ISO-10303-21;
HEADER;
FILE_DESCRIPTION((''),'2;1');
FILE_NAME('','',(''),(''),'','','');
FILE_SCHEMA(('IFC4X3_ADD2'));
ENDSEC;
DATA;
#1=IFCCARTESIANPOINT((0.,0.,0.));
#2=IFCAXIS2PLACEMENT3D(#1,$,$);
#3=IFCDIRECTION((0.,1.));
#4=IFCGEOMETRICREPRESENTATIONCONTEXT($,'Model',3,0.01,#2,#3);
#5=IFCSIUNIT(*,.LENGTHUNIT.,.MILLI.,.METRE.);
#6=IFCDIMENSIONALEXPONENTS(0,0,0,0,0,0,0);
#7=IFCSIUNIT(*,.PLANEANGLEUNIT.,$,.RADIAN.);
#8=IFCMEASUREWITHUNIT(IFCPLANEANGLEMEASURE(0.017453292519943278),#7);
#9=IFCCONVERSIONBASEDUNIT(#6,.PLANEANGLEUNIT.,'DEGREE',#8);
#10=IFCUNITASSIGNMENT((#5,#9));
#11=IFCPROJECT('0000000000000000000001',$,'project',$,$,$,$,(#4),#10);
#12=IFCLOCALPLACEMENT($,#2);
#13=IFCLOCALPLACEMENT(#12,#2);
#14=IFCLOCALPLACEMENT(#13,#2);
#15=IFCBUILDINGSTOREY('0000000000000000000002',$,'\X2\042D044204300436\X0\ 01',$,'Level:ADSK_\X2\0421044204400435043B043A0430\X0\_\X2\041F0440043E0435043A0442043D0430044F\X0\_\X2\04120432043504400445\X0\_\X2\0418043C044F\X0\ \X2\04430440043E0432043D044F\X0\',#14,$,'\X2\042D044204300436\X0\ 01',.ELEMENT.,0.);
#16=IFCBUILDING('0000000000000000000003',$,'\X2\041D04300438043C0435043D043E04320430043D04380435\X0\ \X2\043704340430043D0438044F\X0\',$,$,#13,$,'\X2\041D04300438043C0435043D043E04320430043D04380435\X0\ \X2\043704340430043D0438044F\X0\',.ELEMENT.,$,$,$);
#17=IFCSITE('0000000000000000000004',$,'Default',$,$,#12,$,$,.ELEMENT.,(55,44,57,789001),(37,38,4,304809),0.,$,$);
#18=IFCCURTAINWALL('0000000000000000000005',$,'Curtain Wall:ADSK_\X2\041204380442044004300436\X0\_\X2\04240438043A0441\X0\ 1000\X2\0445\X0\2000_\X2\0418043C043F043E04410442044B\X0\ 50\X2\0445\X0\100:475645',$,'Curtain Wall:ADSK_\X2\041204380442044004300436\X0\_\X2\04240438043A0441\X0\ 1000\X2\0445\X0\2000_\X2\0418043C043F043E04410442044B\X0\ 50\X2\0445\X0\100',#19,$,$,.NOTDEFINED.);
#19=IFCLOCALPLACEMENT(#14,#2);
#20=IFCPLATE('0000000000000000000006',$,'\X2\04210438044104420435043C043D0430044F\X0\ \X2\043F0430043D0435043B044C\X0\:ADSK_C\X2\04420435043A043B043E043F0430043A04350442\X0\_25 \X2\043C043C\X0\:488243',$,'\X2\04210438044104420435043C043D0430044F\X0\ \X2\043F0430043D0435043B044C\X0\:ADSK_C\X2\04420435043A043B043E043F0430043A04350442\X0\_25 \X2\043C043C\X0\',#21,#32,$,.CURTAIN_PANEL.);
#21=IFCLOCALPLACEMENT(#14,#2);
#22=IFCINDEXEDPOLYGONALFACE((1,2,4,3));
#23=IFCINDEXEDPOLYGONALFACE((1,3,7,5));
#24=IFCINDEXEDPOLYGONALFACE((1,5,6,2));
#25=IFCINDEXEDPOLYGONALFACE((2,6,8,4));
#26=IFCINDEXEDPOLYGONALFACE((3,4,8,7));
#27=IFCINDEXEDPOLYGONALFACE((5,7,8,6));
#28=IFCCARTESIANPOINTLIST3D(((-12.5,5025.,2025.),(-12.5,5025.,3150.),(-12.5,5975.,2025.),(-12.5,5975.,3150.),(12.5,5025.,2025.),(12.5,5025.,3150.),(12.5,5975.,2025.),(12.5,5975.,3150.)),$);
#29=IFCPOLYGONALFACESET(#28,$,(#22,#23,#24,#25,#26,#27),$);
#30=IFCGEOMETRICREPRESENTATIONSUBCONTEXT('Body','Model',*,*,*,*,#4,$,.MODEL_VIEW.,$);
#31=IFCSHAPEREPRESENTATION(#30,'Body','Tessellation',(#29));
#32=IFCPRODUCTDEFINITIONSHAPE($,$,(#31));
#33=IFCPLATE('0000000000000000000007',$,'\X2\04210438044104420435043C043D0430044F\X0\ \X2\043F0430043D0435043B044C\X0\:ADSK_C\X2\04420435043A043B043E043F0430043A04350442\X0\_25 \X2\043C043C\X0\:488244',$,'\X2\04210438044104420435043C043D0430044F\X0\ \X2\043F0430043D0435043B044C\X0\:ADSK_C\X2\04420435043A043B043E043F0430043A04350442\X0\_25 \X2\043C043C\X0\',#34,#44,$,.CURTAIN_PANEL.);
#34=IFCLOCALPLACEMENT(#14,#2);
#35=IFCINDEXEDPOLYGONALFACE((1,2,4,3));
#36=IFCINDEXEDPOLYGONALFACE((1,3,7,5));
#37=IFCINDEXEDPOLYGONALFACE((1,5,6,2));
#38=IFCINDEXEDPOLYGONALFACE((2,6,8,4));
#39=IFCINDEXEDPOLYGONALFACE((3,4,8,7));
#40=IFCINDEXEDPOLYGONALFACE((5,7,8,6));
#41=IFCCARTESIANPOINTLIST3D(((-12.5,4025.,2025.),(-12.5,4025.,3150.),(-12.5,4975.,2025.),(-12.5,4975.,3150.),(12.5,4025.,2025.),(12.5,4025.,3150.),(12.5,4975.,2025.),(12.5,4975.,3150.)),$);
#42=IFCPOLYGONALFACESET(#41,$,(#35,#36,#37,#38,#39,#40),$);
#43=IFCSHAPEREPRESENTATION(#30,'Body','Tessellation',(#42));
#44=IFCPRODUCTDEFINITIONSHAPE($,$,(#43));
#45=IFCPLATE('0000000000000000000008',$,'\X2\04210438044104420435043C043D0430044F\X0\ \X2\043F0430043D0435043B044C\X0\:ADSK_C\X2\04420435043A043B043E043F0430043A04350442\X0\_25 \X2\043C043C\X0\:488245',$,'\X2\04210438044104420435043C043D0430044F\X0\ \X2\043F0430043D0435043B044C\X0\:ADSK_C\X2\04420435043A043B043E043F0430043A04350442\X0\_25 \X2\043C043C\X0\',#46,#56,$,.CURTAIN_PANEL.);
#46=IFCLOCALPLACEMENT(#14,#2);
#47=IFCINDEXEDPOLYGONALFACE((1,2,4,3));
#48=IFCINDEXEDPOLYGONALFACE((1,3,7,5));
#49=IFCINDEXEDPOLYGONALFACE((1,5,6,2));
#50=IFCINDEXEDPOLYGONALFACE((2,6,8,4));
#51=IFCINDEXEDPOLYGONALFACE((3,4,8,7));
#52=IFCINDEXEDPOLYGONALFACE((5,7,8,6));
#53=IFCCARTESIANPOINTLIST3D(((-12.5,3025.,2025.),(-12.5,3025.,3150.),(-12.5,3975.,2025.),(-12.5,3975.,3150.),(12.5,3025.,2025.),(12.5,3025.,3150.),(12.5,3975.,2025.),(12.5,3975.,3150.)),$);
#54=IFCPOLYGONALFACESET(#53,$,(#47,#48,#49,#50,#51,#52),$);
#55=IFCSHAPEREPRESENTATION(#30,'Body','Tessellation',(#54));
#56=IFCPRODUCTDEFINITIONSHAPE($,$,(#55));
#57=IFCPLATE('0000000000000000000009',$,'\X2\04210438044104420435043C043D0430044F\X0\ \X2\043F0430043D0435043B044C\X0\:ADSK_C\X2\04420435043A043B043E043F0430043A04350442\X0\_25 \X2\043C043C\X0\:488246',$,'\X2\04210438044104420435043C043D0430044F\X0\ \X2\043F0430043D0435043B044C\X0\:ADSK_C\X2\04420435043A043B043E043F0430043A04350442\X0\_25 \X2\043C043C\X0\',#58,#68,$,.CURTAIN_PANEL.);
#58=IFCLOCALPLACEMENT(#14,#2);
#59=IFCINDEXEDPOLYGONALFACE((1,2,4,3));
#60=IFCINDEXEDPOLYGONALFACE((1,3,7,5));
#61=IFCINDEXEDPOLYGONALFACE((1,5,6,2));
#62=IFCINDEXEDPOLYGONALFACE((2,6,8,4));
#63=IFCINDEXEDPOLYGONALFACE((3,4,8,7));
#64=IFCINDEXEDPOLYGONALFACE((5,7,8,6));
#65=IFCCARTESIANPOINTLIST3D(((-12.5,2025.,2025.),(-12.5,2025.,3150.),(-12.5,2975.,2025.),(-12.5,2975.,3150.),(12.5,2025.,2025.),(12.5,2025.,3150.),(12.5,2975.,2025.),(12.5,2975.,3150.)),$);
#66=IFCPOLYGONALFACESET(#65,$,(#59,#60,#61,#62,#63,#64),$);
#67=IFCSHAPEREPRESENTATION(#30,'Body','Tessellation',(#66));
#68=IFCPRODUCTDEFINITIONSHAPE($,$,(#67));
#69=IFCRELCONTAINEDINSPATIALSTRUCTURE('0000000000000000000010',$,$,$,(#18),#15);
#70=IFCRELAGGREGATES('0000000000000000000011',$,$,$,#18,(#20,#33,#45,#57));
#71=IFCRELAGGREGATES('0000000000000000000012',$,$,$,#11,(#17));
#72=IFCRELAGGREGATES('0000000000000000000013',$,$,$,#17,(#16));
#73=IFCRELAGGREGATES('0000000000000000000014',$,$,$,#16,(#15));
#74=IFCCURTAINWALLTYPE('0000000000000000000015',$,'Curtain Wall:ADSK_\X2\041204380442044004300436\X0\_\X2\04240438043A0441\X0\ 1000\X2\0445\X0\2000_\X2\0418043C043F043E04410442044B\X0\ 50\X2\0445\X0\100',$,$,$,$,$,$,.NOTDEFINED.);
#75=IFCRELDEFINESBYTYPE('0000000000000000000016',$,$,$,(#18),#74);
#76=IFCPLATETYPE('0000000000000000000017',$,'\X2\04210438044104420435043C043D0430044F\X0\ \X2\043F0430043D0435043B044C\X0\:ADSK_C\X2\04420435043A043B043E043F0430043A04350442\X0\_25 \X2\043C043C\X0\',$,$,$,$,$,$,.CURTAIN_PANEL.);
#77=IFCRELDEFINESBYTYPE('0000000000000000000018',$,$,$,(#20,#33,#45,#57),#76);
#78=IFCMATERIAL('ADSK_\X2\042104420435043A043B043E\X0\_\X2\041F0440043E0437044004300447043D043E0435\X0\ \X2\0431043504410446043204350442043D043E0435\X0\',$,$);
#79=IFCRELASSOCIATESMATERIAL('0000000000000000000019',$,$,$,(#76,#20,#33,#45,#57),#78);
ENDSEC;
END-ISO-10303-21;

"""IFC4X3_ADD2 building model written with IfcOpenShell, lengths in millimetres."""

from ifc_helpers import new_model, entity, si_unit, converted_unit, direction, frame, origin, origin_2d_with_axis, place, context, subcontext, project, spatial, rectangle, extrude, source, transform, mapped, material, type_object, type_shapes, element, aggregate, save


model = new_model("IFC4X3_ADD2")

# Units and contexts
model_context = context("Model", 3, precision=0.01, world=origin(), true_north=direction((0.0, 1.0)))
body_context = subcontext(model_context, "Body", "Model", "MODEL_VIEW")
ifc_project = project(units=[si_unit("LENGTHUNIT", "METRE", prefix="MILLI"), converted_unit("PLANEANGLEUNIT", "DEGREE", entity("IfcPlaneAngleMeasure", 0.017453292519943278), si_unit("PLANEANGLEUNIT", "RADIAN"), dimensions=[0, 0, 0, 0, 0, 0, 0])], contexts=[model_context])

# Site, building, storey
site_placement = place(None, origin())
site = spatial("IfcSite", under=ifc_project, at=site_placement, Name="Default", CompositionType="ELEMENT", RefLatitude=(55, 44, 57, 789001), RefLongitude=(37, 38, 4, 304809), RefElevation=0.0)
building_placement = place(site_placement, origin())
building = spatial("IfcBuilding", under=site, at=building_placement, Name="Наименование здания", LongName="Наименование здания", CompositionType="ELEMENT")
storey_placement = place(building_placement, origin())
storey = spatial("IfcBuildingStorey", under=building, at=storey_placement, Name="Этаж 01", ObjectType="Level:ADSK_Стрелка_Проектная_Вверх_Имя уровня", LongName="Этаж 01", CompositionType="ELEMENT", Elevation=0.0)

# Curtain wall, plates
curtain_wall_type = type_object("IfcCurtainWallType", Name="Curtain Wall:ADSK_Витраж_Фикс 1000х2000_Импосты 50х100", PredefinedType="NOTDEFINED")
curtain_wall_placement = place(storey_placement, origin())
curtain_wall = element("IfcCurtainWall", 1, at=curtain_wall_placement, inside=storey, type_object=curtain_wall_type, Name="Curtain Wall:ADSK_Витраж_Фикс 1000х2000_Импосты 50х100:475645", ObjectType="Curtain Wall:ADSK_Витраж_Фикс 1000х2000_Импосты 50х100", PredefinedType="NOTDEFINED")
ifc_material = material(Name="ADSK_Стекло_Прозрачное бесцветное")
plate_type_1 = type_object("IfcPlateType", Name="Системная панель:ADSK_Cтеклопакет_25 мм", PredefinedType="CURTAIN_PANEL", material=ifc_material)
shared_shape_1 = source(origin(), body_context, "Body", "SweptSolid", [
    extrude(rectangle(XDim=25.0, YDim=950.0, at=origin_2d_with_axis()), frame((0.0, 0.0, 0.0), z_axis=(0.0, 0.0, 1.0), x_axis=(0.0, 1.0, 0.0)), (0.0, 0.0, 1.0), 1125.0),
])
type_shapes(plate_type_1, [shared_shape_1])
plate_1_placement = place(curtain_wall_placement, frame((0.0, 5500.0, 2025.0), z_axis=(0.0, 0.0, 1.0), x_axis=(0.0, -1.0, 0.0)))
plate_1 = element("IfcPlate", 2, at=plate_1_placement, type_object=plate_type_1, material=ifc_material, Name="Системная панель:ADSK_Cтеклопакет_25 мм:488243", ObjectType="Системная панель:ADSK_Cтеклопакет_25 мм", PredefinedType="CURTAIN_PANEL", context=body_context, shape_type="MappedRepresentation", body=[
    mapped(shared_shape_1, transform((0.0, 0.0, 0.0), scale=1.0)),
])
plate_2_placement = place(curtain_wall_placement, frame((0.0, 4500.0, 2025.0), z_axis=(0.0, 0.0, 1.0), x_axis=(0.0, -1.0, 0.0)))
plate_2 = element("IfcPlate", 3, at=plate_2_placement, type_object=plate_type_1, material=ifc_material, Name="Системная панель:ADSK_Cтеклопакет_25 мм:488244", ObjectType="Системная панель:ADSK_Cтеклопакет_25 мм", PredefinedType="CURTAIN_PANEL", context=body_context, shape_type="MappedRepresentation", body=[
    mapped(shared_shape_1, transform((0.0, 0.0, 0.0), scale=1.0)),
])
plate_3_placement = place(curtain_wall_placement, frame((0.0, 3500.0, 2025.0), z_axis=(0.0, 0.0, 1.0), x_axis=(0.0, -1.0, 0.0)))
plate_3 = element("IfcPlate", 4, at=plate_3_placement, type_object=plate_type_1, material=ifc_material, Name="Системная панель:ADSK_Cтеклопакет_25 мм:488245", ObjectType="Системная панель:ADSK_Cтеклопакет_25 мм", PredefinedType="CURTAIN_PANEL", context=body_context, shape_type="MappedRepresentation", body=[
    mapped(shared_shape_1, transform((0.0, 0.0, 0.0), scale=1.0)),
])
plate_4_placement = place(curtain_wall_placement, frame((0.0, 2500.0, 2025.0), z_axis=(0.0, 0.0, 1.0), x_axis=(0.0, -1.0, 0.0)))
plate_4 = element("IfcPlate", 5, at=plate_4_placement, type_object=plate_type_1, material=ifc_material, Name="Системная панель:ADSK_Cтеклопакет_25 мм:488246", ObjectType="Системная панель:ADSK_Cтеклопакет_25 мм", PredefinedType="CURTAIN_PANEL", context=body_context, shape_type="MappedRepresentation", body=[
    mapped(shared_shape_1, transform((0.0, 0.0, 0.0), scale=1.0)),
])
aggregate(curtain_wall, [plate_1, plate_2, plate_3, plate_4])

save(model, "model.ifc")
